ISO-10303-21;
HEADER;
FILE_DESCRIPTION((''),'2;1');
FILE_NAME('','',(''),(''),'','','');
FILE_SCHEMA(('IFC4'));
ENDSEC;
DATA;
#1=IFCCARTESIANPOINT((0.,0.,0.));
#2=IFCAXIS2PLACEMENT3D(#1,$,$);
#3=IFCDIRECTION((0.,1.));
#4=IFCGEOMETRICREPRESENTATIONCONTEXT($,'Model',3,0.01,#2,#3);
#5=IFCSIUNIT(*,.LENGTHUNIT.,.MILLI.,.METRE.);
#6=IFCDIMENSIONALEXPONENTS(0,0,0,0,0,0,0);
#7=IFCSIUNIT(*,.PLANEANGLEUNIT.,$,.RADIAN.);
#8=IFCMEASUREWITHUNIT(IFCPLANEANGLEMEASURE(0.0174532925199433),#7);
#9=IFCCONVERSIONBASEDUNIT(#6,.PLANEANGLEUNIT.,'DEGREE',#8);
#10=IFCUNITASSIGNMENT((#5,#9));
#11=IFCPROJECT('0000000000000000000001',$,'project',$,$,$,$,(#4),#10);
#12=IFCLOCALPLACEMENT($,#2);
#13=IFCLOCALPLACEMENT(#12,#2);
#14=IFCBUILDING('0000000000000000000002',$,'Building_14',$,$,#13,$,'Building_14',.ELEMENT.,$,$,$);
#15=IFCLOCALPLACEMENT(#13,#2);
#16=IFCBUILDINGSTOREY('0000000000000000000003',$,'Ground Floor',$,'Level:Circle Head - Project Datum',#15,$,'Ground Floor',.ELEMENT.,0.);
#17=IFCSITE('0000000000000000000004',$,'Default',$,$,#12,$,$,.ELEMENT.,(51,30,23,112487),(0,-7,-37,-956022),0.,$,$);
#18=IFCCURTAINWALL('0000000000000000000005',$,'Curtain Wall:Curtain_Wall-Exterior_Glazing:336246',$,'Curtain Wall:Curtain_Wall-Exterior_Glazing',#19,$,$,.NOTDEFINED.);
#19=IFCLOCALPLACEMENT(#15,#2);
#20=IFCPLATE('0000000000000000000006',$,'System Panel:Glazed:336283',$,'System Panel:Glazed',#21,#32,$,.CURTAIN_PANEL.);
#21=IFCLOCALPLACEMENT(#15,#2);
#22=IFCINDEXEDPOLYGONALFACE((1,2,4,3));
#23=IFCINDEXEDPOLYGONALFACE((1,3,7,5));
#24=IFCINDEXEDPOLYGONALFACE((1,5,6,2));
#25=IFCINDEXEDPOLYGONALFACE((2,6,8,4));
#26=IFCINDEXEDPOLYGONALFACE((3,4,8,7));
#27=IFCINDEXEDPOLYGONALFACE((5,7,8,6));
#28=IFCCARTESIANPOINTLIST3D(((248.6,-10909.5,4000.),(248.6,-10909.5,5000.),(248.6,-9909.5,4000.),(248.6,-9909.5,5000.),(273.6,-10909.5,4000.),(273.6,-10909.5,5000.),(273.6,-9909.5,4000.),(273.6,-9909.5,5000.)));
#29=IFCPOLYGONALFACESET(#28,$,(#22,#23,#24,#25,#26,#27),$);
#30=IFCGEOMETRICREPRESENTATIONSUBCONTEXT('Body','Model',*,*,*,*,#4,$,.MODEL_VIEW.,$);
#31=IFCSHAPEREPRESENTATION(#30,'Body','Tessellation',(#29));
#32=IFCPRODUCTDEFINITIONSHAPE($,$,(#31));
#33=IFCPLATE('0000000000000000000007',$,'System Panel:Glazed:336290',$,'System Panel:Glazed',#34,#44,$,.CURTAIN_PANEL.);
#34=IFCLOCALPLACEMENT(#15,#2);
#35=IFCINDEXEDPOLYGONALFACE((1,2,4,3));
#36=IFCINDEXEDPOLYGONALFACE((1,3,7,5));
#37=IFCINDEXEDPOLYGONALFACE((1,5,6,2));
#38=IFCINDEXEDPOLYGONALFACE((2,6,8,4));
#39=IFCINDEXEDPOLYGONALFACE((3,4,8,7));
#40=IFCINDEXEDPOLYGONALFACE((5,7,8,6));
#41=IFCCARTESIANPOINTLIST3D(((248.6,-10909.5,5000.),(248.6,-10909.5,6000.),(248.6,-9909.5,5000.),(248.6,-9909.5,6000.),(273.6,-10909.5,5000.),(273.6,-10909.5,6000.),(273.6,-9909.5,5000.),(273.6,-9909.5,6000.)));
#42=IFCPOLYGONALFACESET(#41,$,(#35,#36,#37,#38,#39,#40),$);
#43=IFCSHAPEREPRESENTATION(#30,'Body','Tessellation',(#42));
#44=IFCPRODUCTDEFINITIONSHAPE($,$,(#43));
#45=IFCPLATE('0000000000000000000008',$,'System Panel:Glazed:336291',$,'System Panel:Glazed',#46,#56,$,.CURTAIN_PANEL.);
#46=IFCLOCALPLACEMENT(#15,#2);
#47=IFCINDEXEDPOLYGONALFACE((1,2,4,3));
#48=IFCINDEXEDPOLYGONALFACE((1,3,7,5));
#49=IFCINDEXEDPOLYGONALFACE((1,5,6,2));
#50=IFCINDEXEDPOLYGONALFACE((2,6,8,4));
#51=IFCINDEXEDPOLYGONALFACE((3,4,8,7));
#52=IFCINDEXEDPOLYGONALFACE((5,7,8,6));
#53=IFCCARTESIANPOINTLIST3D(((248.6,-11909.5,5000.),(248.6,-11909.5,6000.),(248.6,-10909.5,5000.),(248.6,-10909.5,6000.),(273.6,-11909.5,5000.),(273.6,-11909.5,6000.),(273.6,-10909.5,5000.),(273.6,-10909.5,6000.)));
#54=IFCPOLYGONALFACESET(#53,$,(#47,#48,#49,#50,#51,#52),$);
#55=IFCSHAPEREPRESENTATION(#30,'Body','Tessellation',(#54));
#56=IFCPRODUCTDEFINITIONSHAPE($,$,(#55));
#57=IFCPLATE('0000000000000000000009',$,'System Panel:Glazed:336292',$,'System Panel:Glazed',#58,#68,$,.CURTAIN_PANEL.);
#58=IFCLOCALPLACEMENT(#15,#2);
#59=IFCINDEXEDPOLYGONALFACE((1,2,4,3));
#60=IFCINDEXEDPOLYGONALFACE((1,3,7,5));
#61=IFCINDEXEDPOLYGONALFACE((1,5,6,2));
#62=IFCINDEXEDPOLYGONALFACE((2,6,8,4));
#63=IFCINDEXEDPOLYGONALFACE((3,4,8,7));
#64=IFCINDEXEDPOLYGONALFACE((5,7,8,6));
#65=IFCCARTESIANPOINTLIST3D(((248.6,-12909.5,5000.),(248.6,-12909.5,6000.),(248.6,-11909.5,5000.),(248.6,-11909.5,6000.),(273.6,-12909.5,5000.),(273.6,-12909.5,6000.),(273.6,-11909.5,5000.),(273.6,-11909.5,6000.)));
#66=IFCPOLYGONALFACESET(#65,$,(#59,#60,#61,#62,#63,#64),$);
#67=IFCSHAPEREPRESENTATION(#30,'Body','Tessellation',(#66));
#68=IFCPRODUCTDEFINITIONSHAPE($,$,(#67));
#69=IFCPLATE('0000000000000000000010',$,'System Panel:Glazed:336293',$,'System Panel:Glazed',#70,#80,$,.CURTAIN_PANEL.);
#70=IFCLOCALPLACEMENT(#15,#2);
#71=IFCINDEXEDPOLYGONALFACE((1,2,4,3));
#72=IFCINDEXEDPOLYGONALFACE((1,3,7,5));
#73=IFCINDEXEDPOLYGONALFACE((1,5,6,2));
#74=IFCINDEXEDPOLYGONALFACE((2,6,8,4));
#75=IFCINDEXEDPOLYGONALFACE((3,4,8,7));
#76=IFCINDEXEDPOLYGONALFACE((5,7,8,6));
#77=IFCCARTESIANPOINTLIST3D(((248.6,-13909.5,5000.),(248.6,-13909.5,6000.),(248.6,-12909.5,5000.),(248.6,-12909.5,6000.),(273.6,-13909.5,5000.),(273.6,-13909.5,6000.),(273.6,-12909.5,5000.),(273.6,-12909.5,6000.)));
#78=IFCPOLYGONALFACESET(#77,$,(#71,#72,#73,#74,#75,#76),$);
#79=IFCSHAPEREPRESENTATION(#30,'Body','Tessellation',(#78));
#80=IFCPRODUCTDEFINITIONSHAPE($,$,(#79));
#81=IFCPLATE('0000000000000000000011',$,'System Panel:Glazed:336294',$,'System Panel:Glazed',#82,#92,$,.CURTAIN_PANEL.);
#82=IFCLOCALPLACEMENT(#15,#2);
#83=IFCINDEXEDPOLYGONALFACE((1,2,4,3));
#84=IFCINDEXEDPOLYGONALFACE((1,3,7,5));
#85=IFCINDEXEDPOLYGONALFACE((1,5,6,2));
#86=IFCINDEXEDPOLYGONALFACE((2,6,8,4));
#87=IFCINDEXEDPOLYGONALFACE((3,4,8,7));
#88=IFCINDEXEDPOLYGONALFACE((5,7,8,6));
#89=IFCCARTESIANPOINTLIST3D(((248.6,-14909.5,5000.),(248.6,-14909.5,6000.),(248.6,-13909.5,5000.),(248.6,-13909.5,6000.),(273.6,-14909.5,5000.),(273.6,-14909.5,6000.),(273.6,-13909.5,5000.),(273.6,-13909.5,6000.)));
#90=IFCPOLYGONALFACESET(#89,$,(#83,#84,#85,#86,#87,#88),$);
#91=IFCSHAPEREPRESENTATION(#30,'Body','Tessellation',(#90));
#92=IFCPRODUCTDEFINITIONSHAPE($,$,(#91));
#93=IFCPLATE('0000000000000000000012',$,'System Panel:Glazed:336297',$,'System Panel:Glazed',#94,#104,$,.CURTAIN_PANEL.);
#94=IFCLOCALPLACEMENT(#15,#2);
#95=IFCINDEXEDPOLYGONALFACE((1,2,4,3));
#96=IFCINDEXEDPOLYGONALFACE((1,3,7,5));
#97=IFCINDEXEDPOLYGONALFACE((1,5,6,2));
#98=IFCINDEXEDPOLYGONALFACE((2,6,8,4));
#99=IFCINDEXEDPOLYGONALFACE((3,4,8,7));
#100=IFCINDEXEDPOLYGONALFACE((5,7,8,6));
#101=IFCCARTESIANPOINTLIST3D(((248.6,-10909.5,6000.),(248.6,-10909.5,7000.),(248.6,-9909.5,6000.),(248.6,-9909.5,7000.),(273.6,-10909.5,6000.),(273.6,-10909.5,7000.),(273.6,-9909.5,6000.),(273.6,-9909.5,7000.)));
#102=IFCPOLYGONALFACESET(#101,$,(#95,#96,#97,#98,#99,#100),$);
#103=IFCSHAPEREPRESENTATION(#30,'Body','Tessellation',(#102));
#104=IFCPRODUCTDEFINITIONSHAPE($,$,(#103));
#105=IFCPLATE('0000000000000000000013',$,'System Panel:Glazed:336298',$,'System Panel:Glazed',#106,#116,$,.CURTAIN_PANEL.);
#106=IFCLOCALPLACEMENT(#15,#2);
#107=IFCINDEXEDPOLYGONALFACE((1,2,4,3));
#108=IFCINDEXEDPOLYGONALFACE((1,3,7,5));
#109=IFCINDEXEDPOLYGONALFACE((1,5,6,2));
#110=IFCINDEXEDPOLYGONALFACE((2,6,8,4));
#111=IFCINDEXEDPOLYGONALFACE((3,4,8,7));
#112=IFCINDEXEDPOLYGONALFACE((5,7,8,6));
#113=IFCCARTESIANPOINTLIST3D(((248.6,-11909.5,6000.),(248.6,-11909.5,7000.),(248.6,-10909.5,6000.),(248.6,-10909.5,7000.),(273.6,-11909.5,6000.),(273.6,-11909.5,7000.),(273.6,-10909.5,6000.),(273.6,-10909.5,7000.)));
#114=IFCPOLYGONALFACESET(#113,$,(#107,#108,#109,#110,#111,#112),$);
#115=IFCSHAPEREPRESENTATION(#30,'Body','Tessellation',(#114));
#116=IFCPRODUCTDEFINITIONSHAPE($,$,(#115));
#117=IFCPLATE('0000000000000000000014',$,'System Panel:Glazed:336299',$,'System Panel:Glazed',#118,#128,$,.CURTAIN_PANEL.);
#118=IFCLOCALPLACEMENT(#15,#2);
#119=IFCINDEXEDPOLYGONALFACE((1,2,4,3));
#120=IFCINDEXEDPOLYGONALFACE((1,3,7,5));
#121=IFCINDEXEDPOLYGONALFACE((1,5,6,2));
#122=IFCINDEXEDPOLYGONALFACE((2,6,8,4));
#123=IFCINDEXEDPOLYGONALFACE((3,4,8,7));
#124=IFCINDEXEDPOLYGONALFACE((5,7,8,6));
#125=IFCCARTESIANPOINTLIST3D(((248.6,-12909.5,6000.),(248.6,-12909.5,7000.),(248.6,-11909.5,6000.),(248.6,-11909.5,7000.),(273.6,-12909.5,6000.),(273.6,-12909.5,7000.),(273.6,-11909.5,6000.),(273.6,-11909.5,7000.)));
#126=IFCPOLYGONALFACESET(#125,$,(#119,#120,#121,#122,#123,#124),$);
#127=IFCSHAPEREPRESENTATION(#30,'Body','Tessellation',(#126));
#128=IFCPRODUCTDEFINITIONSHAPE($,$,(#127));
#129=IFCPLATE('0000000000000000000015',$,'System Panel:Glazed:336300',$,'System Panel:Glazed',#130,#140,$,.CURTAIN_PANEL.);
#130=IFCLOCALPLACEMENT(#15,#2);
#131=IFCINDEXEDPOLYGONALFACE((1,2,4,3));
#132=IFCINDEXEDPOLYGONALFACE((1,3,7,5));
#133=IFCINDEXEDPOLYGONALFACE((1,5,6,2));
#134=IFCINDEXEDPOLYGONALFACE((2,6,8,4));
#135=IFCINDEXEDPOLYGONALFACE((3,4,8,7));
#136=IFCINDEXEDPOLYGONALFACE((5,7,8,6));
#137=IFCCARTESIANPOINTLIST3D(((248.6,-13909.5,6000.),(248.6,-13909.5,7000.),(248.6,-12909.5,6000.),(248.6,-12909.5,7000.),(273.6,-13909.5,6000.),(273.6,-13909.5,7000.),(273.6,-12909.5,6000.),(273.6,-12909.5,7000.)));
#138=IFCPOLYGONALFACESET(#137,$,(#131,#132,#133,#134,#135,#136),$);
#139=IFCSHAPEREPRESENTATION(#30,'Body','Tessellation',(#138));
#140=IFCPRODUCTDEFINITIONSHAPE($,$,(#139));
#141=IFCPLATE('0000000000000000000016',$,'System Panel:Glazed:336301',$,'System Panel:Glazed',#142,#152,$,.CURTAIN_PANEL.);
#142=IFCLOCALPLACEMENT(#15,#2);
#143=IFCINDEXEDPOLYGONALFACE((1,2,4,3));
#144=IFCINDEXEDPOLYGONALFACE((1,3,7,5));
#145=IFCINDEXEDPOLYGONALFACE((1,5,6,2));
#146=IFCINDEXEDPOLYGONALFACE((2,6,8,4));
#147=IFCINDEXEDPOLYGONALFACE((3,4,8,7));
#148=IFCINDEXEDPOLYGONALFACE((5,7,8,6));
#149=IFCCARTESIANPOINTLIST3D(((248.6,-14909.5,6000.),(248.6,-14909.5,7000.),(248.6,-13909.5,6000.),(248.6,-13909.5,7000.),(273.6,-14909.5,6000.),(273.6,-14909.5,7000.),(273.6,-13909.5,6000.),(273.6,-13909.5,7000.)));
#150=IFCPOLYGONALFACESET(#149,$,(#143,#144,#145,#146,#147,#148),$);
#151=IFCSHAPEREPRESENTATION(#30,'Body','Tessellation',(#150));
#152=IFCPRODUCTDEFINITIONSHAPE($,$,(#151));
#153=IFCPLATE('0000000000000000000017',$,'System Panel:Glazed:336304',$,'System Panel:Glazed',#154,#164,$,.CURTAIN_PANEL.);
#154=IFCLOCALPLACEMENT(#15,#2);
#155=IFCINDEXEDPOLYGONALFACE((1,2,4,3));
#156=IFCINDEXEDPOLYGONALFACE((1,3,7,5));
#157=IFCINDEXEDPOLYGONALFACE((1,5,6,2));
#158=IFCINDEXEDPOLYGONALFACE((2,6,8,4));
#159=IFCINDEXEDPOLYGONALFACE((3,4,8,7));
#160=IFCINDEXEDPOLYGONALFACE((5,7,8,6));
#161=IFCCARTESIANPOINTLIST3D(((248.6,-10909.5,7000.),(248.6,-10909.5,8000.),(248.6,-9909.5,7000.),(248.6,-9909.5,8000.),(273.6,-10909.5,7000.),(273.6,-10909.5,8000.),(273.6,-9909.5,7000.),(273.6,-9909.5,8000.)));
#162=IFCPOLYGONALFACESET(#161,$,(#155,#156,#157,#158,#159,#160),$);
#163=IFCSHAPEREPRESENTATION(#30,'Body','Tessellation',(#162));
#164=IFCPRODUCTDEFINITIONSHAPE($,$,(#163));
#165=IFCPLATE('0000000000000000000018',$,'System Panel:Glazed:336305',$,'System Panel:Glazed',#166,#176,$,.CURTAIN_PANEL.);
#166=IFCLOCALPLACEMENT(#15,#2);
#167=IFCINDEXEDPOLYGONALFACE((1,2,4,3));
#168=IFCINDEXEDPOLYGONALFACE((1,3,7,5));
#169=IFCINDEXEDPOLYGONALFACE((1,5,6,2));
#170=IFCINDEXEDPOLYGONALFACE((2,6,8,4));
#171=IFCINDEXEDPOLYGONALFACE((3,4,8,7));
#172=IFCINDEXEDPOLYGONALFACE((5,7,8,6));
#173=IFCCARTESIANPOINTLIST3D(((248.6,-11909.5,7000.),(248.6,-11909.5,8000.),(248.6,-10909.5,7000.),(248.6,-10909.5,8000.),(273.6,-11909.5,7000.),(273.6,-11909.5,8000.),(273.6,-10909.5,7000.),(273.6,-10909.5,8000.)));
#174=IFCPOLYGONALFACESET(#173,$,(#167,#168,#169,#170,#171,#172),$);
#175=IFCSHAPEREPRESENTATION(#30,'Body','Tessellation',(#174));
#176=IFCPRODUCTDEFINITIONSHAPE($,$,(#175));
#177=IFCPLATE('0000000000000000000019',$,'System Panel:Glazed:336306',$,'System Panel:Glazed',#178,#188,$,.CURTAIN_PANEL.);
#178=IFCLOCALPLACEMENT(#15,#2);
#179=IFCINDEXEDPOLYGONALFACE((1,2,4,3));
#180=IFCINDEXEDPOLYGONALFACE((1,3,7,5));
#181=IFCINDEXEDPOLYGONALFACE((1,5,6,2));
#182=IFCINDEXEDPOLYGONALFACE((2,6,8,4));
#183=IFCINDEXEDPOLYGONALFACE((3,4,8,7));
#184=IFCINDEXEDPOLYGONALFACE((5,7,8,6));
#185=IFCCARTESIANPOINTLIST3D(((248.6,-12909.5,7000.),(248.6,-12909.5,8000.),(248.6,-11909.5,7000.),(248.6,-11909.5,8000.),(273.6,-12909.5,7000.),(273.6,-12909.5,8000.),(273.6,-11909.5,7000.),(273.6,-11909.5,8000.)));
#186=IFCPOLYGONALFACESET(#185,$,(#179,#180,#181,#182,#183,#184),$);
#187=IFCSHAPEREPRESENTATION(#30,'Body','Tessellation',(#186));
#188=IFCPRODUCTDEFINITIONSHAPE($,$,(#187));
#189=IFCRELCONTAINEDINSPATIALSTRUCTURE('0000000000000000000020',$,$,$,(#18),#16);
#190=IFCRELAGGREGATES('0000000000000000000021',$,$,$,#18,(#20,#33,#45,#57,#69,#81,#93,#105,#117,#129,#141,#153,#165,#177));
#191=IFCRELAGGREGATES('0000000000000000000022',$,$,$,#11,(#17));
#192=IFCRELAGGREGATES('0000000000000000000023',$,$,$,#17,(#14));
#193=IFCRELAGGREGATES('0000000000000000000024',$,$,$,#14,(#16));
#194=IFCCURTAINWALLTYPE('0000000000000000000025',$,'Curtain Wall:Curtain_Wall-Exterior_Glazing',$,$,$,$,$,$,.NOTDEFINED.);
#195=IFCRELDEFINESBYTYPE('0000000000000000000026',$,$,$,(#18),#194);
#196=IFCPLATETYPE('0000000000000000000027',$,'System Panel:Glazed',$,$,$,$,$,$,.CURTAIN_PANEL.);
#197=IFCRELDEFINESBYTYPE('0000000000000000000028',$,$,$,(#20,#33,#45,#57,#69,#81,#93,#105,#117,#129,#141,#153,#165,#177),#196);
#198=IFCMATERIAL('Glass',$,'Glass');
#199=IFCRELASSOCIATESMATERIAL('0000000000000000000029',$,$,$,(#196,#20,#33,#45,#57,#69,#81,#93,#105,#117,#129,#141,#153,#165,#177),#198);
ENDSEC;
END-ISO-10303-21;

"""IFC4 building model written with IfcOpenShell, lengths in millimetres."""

from ifc_helpers import new_model, entity, si_unit, converted_unit, direction, frame, origin, place, context, subcontext, project, spatial, indexed_curve, outline, extrude, source, transform, mapped, material, type_object, type_shapes, element, aggregate, save


model = new_model("IFC4")

# Units and contexts
model_context = context("Model", 3, precision=0.01, world=origin(), true_north=direction((0.0, 1.0)))
body_context = subcontext(model_context, "Body", "Model", "MODEL_VIEW")
ifc_project = project(units=[si_unit("LENGTHUNIT", "METRE", prefix="MILLI"), converted_unit("PLANEANGLEUNIT", "DEGREE", entity("IfcPlaneAngleMeasure", 0.0174532925199433), si_unit("PLANEANGLEUNIT", "RADIAN"), dimensions=[0, 0, 0, 0, 0, 0, 0])], contexts=[model_context])

# Site, building, storey
site_placement = place(None, origin())
site = spatial("IfcSite", under=ifc_project, at=site_placement, Name="Default", CompositionType="ELEMENT", RefLatitude=(51, 30, 23, 112487), RefLongitude=(0, -7, -37, -956022), RefElevation=0.0)
building_placement = place(site_placement, origin())
building = spatial("IfcBuilding", under=site, at=building_placement, Name="Building_14", LongName="Building_14", CompositionType="ELEMENT")
storey_placement = place(building_placement, origin())
storey = spatial("IfcBuildingStorey", under=building, at=storey_placement, Name="Ground Floor", ObjectType="Level:Circle Head - Project Datum", LongName="Ground Floor", CompositionType="ELEMENT", Elevation=0.0)

# Curtain wall, plates
curtain_wall_type = type_object("IfcCurtainWallType", Name="Curtain Wall:Curtain_Wall-Exterior_Glazing", PredefinedType="NOTDEFINED")
curtain_wall_1_placement = place(storey_placement, origin())
curtain_wall_1 = element("IfcCurtainWall", 1, at=curtain_wall_1_placement, inside=storey, type_object=curtain_wall_type, Name="Curtain Wall:Curtain_Wall-Exterior_Glazing:336246", ObjectType="Curtain Wall:Curtain_Wall-Exterior_Glazing", PredefinedType="NOTDEFINED")
ifc_material = material(Name="Glass", Category="Glass")
plate_type_1 = type_object("IfcPlateType", Name="System Panel:Glazed", PredefinedType="CURTAIN_PANEL", material=ifc_material)
shared_shape_1 = source(origin(), body_context, "Body", "SweptSolid", [
    extrude(outline(indexed_curve([(-12.5, -500.0), (12.5, -500.0), (12.5, 500.0), (-12.5, 500.0), (-12.5, -500.0)], self_intersect=False)), frame((0.0, -37.0, 0.0), z_axis=(0.0, 0.0, 1.0), x_axis=(0.0, 1.0, 0.0)), (0.0, 0.0, 1.0), 1000.0),
])
type_shapes(plate_type_1, [shared_shape_1])
plate_1_placement = place(curtain_wall_1_placement, frame((298.1, -10409.5, 4000.0), z_axis=(0.0, 0.0, 1.0), x_axis=(0.0, -1.0, 0.0)))
plate_1 = element("IfcPlate", 2, at=plate_1_placement, type_object=plate_type_1, material=ifc_material, Name="System Panel:Glazed:336283", ObjectType="System Panel:Glazed", PredefinedType="CURTAIN_PANEL", context=body_context, shape_type="MappedRepresentation", body=[
    mapped(shared_shape_1, transform((0.0, 0.0, 0.0), scale=1.0)),
])
plate_2_placement = place(curtain_wall_1_placement, frame((298.1, -10409.5, 5000.0), z_axis=(0.0, 0.0, 1.0), x_axis=(0.0, -1.0, 0.0)))
plate_2 = element("IfcPlate", 3, at=plate_2_placement, type_object=plate_type_1, material=ifc_material, Name="System Panel:Glazed:336290", ObjectType="System Panel:Glazed", PredefinedType="CURTAIN_PANEL", context=body_context, shape_type="MappedRepresentation", body=[
    mapped(shared_shape_1, transform((0.0, 0.0, 0.0), scale=1.0)),
])
plate_3_placement = place(curtain_wall_1_placement, frame((298.1, -11409.5, 5000.0), z_axis=(0.0, 0.0, 1.0), x_axis=(0.0, -1.0, 0.0)))
plate_3 = element("IfcPlate", 4, at=plate_3_placement, type_object=plate_type_1, material=ifc_material, Name="System Panel:Glazed:336291", ObjectType="System Panel:Glazed", PredefinedType="CURTAIN_PANEL", context=body_context, shape_type="MappedRepresentation", body=[
    mapped(shared_shape_1, transform((0.0, 0.0, 0.0), scale=1.0)),
])
plate_4_placement = place(curtain_wall_1_placement, frame((298.1, -12409.5, 5000.0), z_axis=(0.0, 0.0, 1.0), x_axis=(0.0, -1.0, 0.0)))
plate_4 = element("IfcPlate", 5, at=plate_4_placement, type_object=plate_type_1, material=ifc_material, Name="System Panel:Glazed:336292", ObjectType="System Panel:Glazed", PredefinedType="CURTAIN_PANEL", context=body_context, shape_type="MappedRepresentation", body=[
    mapped(shared_shape_1, transform((0.0, 0.0, 0.0), scale=1.0)),
])
plate_5_placement = place(curtain_wall_1_placement, frame((298.1, -13409.5, 5000.0), z_axis=(0.0, 0.0, 1.0), x_axis=(0.0, -1.0, 0.0)))
plate_5 = element("IfcPlate", 6, at=plate_5_placement, type_object=plate_type_1, material=ifc_material, Name="System Panel:Glazed:336293", ObjectType="System Panel:Glazed", PredefinedType="CURTAIN_PANEL", context=body_context, shape_type="MappedRepresentation", body=[
    mapped(shared_shape_1, transform((0.0, 0.0, 0.0), scale=1.0)),
])
plate_6_placement = place(curtain_wall_1_placement, frame((298.1, -14409.5, 5000.0), z_axis=(0.0, 0.0, 1.0), x_axis=(0.0, -1.0, 0.0)))
plate_6 = element("IfcPlate", 7, at=plate_6_placement, type_object=plate_type_1, material=ifc_material, Name="System Panel:Glazed:336294", ObjectType="System Panel:Glazed", PredefinedType="CURTAIN_PANEL", context=body_context, shape_type="MappedRepresentation", body=[
    mapped(shared_shape_1, transform((0.0, 0.0, 0.0), scale=1.0)),
])
plate_7_placement = place(curtain_wall_1_placement, frame((298.1, -10409.5, 6000.0), z_axis=(0.0, 0.0, 1.0), x_axis=(0.0, -1.0, 0.0)))
plate_7 = element("IfcPlate", 8, at=plate_7_placement, type_object=plate_type_1, material=ifc_material, Name="System Panel:Glazed:336297", ObjectType="System Panel:Glazed", PredefinedType="CURTAIN_PANEL", context=body_context, shape_type="MappedRepresentation", body=[
    mapped(shared_shape_1, transform((0.0, 0.0, 0.0), scale=1.0)),
])
plate_8_placement = place(curtain_wall_1_placement, frame((298.1, -11409.5, 6000.0), z_axis=(0.0, 0.0, 1.0), x_axis=(0.0, -1.0, 0.0)))
plate_8 = element("IfcPlate", 9, at=plate_8_placement, type_object=plate_type_1, material=ifc_material, Name="System Panel:Glazed:336298", ObjectType="System Panel:Glazed", PredefinedType="CURTAIN_PANEL", context=body_context, shape_type="MappedRepresentation", body=[
    mapped(shared_shape_1, transform((0.0, 0.0, 0.0), scale=1.0)),
])
plate_9_placement = place(curtain_wall_1_placement, frame((298.1, -12409.5, 6000.0), z_axis=(0.0, 0.0, 1.0), x_axis=(0.0, -1.0, 0.0)))
plate_9 = element("IfcPlate", 10, at=plate_9_placement, type_object=plate_type_1, material=ifc_material, Name="System Panel:Glazed:336299", ObjectType="System Panel:Glazed", PredefinedType="CURTAIN_PANEL", context=body_context, shape_type="MappedRepresentation", body=[
    mapped(shared_shape_1, transform((0.0, 0.0, 0.0), scale=1.0)),
])
plate_10_placement = place(curtain_wall_1_placement, frame((298.1, -13409.5, 6000.0), z_axis=(0.0, 0.0, 1.0), x_axis=(0.0, -1.0, 0.0)))
plate_10 = element("IfcPlate", 11, at=plate_10_placement, type_object=plate_type_1, material=ifc_material, Name="System Panel:Glazed:336300", ObjectType="System Panel:Glazed", PredefinedType="CURTAIN_PANEL", context=body_context, shape_type="MappedRepresentation", body=[
    mapped(shared_shape_1, transform((0.0, 0.0, 0.0), scale=1.0)),
])
plate_11_placement = place(curtain_wall_1_placement, frame((298.1, -14409.5, 6000.0), z_axis=(0.0, 0.0, 1.0), x_axis=(0.0, -1.0, 0.0)))
plate_11 = element("IfcPlate", 12, at=plate_11_placement, type_object=plate_type_1, material=ifc_material, Name="System Panel:Glazed:336301", ObjectType="System Panel:Glazed", PredefinedType="CURTAIN_PANEL", context=body_context, shape_type="MappedRepresentation", body=[
    mapped(shared_shape_1, transform((0.0, 0.0, 0.0), scale=1.0)),
])
plate_12_placement = place(curtain_wall_1_placement, frame((298.1, -10409.5, 7000.0), z_axis=(0.0, 0.0, 1.0), x_axis=(0.0, -1.0, 0.0)))
plate_12 = element("IfcPlate", 13, at=plate_12_placement, type_object=plate_type_1, material=ifc_material, Name="System Panel:Glazed:336304", ObjectType="System Panel:Glazed", PredefinedType="CURTAIN_PANEL", context=body_context, shape_type="MappedRepresentation", body=[
    mapped(shared_shape_1, transform((0.0, 0.0, 0.0), scale=1.0)),
])
plate_13_placement = place(curtain_wall_1_placement, frame((298.1, -11409.5, 7000.0), z_axis=(0.0, 0.0, 1.0), x_axis=(0.0, -1.0, 0.0)))
plate_13 = element("IfcPlate", 14, at=plate_13_placement, type_object=plate_type_1, material=ifc_material, Name="System Panel:Glazed:336305", ObjectType="System Panel:Glazed", PredefinedType="CURTAIN_PANEL", context=body_context, shape_type="MappedRepresentation", body=[
    mapped(shared_shape_1, transform((0.0, 0.0, 0.0), scale=1.0)),
])
plate_14_placement = place(curtain_wall_1_placement, frame((298.1, -12409.5, 7000.0), z_axis=(0.0, 0.0, 1.0), x_axis=(0.0, -1.0, 0.0)))
plate_14 = element("IfcPlate", 15, at=plate_14_placement, type_object=plate_type_1, material=ifc_material, Name="System Panel:Glazed:336306", ObjectType="System Panel:Glazed", PredefinedType="CURTAIN_PANEL", context=body_context, shape_type="MappedRepresentation", body=[
    mapped(shared_shape_1, transform((0.0, 0.0, 0.0), scale=1.0)),
])
aggregate(curtain_wall_1, [plate_1, plate_2, plate_3, plate_4, plate_5, plate_6, plate_7, plate_8, plate_9, plate_10, plate_11, plate_12, plate_13, plate_14])

save(model, "model.ifc")
